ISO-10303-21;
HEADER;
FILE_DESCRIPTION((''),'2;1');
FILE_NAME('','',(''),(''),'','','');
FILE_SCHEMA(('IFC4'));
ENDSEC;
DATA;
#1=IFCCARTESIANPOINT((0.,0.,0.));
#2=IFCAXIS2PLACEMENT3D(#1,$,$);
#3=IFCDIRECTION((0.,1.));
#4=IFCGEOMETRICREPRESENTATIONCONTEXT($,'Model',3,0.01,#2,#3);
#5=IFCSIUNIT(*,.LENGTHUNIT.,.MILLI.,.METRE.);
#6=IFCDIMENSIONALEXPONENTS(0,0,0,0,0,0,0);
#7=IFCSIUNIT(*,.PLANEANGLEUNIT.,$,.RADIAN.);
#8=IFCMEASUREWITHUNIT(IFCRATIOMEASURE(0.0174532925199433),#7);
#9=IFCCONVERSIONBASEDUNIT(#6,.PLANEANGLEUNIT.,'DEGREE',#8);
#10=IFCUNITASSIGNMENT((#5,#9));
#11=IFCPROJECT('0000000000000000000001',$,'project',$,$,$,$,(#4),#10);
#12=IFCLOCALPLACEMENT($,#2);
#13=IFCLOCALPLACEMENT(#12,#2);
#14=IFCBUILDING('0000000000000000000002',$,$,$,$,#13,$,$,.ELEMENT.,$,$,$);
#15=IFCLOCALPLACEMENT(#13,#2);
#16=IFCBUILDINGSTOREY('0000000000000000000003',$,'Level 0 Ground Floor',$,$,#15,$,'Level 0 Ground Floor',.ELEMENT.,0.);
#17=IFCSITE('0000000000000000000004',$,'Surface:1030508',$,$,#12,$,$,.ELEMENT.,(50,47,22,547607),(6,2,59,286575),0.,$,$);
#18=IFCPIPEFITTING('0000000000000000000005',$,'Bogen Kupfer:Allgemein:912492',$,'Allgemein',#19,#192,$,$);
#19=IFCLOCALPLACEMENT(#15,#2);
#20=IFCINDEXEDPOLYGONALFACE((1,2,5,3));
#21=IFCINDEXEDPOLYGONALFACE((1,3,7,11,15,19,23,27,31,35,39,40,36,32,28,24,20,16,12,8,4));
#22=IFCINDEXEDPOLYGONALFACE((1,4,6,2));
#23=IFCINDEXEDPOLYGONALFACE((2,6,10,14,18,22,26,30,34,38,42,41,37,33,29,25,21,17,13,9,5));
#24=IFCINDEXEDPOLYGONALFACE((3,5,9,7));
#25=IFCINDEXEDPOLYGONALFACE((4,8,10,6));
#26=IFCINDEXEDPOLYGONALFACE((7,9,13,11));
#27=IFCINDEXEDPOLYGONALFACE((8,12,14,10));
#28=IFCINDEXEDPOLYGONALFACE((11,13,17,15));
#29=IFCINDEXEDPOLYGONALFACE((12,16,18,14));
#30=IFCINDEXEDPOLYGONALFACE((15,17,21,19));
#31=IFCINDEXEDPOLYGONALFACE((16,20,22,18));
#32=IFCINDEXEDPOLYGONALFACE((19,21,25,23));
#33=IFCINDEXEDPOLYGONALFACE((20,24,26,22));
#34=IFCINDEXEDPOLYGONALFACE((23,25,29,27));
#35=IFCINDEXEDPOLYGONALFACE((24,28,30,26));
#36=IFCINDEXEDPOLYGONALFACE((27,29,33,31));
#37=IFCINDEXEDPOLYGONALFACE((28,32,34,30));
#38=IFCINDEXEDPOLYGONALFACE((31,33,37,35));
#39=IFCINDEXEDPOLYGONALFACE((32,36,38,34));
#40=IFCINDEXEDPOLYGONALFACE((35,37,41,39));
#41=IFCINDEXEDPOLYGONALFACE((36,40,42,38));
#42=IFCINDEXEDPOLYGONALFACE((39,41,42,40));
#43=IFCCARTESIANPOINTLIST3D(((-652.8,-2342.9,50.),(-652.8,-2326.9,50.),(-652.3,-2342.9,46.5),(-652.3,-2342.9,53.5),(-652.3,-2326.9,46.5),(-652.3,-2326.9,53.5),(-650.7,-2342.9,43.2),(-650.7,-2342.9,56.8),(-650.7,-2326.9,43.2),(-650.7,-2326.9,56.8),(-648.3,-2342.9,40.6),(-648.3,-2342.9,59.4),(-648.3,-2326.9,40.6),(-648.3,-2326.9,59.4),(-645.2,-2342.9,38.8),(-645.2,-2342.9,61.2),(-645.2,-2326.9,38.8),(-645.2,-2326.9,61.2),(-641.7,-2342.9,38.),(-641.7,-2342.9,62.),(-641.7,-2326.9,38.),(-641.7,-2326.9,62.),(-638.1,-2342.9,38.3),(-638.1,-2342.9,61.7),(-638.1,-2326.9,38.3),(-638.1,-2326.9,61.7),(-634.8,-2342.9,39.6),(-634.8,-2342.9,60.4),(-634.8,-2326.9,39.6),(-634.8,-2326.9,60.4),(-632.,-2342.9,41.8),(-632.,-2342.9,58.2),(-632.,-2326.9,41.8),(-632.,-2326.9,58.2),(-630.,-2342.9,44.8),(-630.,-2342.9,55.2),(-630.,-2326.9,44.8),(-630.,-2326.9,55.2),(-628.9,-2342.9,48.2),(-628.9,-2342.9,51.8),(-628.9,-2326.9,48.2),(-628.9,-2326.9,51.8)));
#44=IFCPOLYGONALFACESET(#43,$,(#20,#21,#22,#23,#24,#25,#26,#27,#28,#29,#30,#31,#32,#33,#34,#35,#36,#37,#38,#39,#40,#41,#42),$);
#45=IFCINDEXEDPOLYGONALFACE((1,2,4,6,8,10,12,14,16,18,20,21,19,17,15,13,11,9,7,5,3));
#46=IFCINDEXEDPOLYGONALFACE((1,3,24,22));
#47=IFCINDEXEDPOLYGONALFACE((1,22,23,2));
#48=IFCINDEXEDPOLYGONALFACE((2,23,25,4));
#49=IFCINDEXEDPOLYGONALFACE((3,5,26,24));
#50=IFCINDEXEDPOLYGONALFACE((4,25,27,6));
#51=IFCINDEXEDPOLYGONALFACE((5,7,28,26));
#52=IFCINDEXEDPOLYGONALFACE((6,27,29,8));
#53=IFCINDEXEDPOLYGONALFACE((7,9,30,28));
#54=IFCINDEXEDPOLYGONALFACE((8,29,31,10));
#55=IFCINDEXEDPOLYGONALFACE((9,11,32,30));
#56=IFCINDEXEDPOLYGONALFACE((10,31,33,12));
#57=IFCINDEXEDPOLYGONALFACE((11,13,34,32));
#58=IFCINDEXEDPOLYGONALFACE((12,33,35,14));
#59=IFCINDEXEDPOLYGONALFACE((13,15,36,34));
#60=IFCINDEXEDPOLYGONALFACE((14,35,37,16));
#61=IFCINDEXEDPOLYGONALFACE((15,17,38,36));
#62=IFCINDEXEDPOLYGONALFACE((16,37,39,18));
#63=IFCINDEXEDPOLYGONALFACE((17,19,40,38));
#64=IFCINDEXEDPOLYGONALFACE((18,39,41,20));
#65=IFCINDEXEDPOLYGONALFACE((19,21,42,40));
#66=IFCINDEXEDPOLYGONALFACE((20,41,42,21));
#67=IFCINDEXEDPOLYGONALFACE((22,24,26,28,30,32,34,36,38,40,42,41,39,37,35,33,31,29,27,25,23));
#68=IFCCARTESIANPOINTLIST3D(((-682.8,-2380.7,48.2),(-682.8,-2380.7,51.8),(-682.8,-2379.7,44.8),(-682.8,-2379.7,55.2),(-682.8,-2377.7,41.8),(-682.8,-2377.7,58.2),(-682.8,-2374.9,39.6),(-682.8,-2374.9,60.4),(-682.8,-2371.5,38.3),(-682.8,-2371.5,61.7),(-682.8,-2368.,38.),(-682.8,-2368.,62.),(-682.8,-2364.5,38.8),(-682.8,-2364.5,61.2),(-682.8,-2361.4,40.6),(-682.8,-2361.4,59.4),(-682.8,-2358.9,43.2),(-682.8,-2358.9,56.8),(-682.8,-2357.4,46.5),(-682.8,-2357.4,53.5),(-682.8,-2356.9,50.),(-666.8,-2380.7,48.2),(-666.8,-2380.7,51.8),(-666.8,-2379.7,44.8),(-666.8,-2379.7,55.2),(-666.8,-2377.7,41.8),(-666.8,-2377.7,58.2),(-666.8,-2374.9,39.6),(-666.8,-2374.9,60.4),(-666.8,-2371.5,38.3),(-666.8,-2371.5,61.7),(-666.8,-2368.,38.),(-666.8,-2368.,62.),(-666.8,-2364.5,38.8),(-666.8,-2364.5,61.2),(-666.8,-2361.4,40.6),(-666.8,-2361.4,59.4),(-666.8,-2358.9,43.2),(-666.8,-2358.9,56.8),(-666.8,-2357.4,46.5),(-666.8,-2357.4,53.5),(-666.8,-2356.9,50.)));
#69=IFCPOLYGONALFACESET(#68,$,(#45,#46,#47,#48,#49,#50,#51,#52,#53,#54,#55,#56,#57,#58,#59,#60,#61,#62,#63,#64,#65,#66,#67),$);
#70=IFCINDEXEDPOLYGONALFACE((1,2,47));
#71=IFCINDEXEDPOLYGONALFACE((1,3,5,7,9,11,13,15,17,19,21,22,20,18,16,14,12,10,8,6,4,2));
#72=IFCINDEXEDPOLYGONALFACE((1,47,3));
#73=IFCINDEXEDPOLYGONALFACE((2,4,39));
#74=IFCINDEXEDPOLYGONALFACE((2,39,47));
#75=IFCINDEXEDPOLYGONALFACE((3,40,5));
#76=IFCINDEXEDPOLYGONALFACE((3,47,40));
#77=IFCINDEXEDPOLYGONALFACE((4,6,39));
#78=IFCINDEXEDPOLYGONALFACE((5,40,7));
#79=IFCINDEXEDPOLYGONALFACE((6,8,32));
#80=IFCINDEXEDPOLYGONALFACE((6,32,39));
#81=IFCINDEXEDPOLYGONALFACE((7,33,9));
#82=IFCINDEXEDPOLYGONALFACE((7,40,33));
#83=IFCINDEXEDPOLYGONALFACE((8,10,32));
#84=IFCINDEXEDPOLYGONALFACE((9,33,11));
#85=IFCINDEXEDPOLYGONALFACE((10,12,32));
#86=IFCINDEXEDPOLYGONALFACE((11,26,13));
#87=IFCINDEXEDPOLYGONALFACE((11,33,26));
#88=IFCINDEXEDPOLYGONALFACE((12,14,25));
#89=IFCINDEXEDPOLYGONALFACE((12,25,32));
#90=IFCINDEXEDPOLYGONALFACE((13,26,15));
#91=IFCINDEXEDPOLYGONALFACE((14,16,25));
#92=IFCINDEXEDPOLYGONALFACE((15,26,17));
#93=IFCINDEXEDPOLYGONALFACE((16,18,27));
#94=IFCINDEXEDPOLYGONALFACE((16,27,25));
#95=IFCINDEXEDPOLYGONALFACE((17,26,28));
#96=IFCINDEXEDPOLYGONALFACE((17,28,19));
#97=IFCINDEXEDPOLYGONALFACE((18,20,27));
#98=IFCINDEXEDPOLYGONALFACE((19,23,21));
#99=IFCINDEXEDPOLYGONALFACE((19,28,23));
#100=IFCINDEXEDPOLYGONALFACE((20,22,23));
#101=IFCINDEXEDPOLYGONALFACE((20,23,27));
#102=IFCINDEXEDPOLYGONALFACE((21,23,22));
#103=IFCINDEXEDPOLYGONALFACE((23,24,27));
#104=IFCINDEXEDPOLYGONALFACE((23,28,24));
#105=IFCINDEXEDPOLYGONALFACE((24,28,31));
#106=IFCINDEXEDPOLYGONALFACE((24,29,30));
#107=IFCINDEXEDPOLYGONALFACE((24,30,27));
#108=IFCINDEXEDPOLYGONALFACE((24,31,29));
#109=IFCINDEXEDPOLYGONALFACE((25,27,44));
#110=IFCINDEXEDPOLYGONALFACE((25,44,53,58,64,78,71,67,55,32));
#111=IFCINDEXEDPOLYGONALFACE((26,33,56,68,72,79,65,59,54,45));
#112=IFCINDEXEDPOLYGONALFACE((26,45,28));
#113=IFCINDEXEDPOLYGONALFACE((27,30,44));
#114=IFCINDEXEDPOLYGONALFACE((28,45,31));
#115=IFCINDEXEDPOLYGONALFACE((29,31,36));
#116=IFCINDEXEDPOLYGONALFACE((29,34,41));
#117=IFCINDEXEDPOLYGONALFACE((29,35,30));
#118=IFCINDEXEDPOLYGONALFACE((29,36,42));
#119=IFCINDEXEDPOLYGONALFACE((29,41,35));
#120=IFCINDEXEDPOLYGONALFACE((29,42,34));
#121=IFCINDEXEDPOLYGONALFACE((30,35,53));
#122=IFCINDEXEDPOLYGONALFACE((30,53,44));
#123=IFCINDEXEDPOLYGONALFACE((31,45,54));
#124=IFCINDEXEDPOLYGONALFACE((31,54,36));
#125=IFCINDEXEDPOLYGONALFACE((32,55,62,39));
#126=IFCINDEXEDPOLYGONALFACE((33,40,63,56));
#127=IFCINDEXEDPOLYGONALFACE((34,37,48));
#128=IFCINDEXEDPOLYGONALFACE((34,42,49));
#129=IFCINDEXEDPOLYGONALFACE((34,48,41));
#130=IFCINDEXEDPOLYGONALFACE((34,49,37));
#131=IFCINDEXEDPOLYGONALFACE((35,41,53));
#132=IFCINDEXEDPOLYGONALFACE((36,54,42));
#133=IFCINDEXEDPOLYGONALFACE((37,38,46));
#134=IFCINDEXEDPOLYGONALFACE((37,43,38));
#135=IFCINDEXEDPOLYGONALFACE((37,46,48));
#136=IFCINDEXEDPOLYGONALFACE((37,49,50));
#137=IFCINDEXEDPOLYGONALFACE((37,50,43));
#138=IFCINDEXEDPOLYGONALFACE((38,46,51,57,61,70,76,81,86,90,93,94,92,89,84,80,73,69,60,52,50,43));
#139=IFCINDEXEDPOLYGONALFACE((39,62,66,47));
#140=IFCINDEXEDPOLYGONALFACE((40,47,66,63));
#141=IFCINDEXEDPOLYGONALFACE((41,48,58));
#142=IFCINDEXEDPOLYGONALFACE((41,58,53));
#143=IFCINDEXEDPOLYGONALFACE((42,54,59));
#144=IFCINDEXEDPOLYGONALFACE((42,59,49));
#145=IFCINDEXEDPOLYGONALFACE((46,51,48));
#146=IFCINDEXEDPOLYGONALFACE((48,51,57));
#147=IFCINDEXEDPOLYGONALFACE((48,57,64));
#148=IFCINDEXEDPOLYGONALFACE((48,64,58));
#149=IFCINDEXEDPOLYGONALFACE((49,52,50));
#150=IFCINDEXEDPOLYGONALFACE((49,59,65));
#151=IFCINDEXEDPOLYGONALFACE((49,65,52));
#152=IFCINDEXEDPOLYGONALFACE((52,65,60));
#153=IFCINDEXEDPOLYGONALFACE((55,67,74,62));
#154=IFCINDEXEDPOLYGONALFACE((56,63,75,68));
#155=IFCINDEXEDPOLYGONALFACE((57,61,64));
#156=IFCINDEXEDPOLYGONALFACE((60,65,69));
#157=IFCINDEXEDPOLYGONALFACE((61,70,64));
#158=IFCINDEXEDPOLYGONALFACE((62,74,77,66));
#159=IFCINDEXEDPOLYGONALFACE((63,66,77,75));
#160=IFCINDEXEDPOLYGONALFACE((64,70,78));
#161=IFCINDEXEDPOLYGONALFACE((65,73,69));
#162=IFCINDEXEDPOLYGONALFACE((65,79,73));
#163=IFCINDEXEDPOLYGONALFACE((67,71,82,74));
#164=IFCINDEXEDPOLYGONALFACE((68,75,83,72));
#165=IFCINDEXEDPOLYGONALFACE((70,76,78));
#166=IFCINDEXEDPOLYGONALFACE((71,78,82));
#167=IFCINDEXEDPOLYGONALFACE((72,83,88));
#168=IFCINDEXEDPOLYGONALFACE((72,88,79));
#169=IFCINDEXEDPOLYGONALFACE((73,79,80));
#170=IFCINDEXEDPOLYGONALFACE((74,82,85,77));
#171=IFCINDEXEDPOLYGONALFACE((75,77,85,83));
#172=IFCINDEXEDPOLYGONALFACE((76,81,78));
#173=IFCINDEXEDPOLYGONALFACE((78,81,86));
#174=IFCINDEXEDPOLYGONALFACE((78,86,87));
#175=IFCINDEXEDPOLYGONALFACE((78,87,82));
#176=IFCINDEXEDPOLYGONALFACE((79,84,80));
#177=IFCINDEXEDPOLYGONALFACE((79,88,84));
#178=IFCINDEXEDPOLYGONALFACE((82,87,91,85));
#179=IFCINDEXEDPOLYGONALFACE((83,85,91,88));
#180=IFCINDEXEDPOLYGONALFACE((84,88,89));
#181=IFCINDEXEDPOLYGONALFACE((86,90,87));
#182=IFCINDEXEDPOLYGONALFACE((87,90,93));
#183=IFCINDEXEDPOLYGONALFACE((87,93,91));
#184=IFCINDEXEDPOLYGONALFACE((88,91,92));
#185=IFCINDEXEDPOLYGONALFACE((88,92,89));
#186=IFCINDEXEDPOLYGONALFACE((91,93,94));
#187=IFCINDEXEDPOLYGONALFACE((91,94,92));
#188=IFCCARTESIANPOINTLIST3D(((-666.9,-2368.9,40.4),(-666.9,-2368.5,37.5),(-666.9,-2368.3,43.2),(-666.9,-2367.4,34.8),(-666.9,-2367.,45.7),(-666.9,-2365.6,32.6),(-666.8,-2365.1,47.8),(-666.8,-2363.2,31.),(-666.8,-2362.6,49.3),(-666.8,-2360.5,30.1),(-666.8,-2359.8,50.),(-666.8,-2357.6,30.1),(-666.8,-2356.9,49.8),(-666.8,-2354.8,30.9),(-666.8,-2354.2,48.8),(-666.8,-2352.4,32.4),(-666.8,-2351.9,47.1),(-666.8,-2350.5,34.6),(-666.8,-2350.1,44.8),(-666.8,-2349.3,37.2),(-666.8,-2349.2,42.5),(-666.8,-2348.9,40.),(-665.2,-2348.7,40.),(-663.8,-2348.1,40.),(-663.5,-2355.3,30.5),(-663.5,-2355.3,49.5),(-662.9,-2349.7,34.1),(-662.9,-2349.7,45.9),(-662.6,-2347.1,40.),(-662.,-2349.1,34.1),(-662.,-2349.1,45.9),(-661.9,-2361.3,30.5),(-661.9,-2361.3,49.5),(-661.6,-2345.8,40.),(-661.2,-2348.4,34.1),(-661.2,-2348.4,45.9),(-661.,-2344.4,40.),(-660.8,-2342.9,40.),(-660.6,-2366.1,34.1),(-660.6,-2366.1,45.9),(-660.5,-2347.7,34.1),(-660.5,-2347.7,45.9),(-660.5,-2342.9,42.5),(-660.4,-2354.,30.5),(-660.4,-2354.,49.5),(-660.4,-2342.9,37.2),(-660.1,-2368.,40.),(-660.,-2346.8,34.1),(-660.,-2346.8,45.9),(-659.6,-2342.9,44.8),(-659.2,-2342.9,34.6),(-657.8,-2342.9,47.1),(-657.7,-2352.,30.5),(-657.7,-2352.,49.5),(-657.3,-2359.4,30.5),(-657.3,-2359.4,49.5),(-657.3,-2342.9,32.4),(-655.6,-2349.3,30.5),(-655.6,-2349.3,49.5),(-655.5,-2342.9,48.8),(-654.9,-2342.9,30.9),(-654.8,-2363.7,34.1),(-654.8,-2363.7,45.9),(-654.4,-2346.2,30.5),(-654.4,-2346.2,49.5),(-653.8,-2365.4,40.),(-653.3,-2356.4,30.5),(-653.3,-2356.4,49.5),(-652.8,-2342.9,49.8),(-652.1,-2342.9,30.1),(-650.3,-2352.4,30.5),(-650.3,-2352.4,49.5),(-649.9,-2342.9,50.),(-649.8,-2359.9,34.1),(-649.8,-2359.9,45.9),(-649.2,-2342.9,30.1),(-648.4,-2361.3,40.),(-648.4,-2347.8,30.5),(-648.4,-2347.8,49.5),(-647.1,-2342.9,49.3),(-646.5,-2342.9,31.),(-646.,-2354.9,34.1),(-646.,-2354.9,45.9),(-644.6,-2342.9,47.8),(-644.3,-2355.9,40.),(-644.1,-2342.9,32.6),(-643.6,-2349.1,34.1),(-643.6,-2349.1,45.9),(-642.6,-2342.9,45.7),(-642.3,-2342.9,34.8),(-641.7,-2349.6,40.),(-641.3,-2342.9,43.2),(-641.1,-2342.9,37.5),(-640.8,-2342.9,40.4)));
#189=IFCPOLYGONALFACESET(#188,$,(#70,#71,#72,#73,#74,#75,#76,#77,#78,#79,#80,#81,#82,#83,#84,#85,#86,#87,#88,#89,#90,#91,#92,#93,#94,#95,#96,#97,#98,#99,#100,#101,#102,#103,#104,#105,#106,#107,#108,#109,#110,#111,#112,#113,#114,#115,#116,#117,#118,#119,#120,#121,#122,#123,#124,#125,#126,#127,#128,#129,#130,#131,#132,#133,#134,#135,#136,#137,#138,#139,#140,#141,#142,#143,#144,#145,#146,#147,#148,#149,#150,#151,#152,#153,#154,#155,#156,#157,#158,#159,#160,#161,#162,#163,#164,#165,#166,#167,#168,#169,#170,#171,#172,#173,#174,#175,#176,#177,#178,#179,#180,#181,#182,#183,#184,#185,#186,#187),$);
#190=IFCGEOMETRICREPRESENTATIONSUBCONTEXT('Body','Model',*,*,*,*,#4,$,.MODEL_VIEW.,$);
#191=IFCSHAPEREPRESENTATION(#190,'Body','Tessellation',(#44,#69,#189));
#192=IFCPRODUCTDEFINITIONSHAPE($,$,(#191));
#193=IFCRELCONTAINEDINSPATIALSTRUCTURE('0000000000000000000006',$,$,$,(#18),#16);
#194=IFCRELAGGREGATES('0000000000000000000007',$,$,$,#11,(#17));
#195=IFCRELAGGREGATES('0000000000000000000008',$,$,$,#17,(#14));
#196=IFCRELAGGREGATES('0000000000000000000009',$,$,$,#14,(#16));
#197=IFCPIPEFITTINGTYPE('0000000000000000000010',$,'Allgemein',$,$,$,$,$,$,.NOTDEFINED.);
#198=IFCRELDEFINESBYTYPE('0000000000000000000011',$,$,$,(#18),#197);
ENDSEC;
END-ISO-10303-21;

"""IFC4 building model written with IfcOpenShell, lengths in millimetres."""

from ifc_helpers import new_model, entity, si_unit, converted_unit, direction, frame, frame_2d, origin, place, context, subcontext, project, spatial, circle, extrude, source, transform, mapped, type_object, type_shapes, element, save


model = new_model("IFC4")

# Units and contexts
model_context = context("Model", 3, precision=0.01, world=origin(), true_north=direction((0.0, 1.0)))
body_context = subcontext(model_context, "Body", "Model", "MODEL_VIEW")
ifc_project = project(units=[si_unit("LENGTHUNIT", "METRE", prefix="MILLI"), converted_unit("PLANEANGLEUNIT", "DEGREE", entity("IfcRatioMeasure", 0.0174532925199433), si_unit("PLANEANGLEUNIT", "RADIAN"), dimensions=[0, 0, 0, 0, 0, 0, 0])], contexts=[model_context])

# Site, building, storey
site_placement = place(None, origin())
site = spatial("IfcSite", under=ifc_project, at=site_placement, Name="Surface:1030508", CompositionType="ELEMENT", RefLatitude=(50, 47, 22, 547607), RefLongitude=(6, 2, 59, 286575), RefElevation=0.0)
building_placement = place(site_placement, origin())
building = spatial("IfcBuilding", under=site, at=building_placement, CompositionType="ELEMENT")
storey_placement = place(building_placement, origin())
storey = spatial("IfcBuildingStorey", under=building, at=storey_placement, Name="Level 0 Ground Floor", LongName="Level 0 Ground Floor", CompositionType="ELEMENT", Elevation=0.0)

# Pipe fitting
pipe_fitting_type_1 = type_object("IfcPipeFittingType", Name="Allgemein", PredefinedType="NOTDEFINED")
ifc_direction_1 = entity("IfcDirection", [0.0, 0.0, -1.0])
trimmed_curve_1 = entity("IfcTrimmedCurve", entity("IfcCircle", entity("IfcAxis2Placement2D", entity("IfcCartesianPoint", [-16.0, 0.0]), entity("IfcDirection", [0.0, 1.0])), 16.0), [entity("IfcParameterValue", 270.0)], [entity("IfcParameterValue", 0.0)], True, "PARAMETER")
shared_shape_1 = source(origin(), body_context, "Body", "SolidModel", [
    extrude(circle(Radius=12.0, at=frame_2d((0.0, 0.0), x_axis=(1.0, 0.0))), frame((0.0, 26.0, 0.0), z_axis=(0.0, 1.0, 0.0), x_axis=(-1.0, 0.0, 0.0)), (0.0, 0.0, 1.0), 16.0),
    extrude(circle(Radius=12.0, at=frame_2d((0.0, 0.0), x_axis=(1.0, 0.0))), frame((-42.0, 0.0, 0.0), z_axis=(1.0, 0.0, 0.0), x_axis=(0.0, 1.0, 0.0)), (0.0, 0.0, 1.0), 16.0),
    entity("IfcSurfaceCurveSweptAreaSolid", entity("IfcCircleProfileDef", "AREA", None, entity("IfcAxis2Placement2D", entity("IfcCartesianPoint", [0.0, 10.0]), entity("IfcDirection", [1.0, 0.0])), 10.0), entity("IfcAxis2Placement3D", entity("IfcCartesianPoint", [-10.0, 26.0, 0.0]), ifc_direction_1, entity("IfcDirection", [1.0, 0.0, 0.0])), trimmed_curve_1, 0.0, 90.0, entity("IfcSurfaceOfLinearExtrusion", entity("IfcArbitraryOpenProfileDef", "CURVE", None, trimmed_curve_1), entity("IfcAxis2Placement3D", entity("IfcCartesianPoint", [0.0, 0.0, -304.8])), ifc_direction_1, 1.0)),
])
type_shapes(pipe_fitting_type_1, [shared_shape_1])
pipe_fitting_1_placement = place(storey_placement, frame((-640.8, -2368.9, 50.0)))
element("IfcPipeFitting", 1, at=pipe_fitting_1_placement, inside=storey, type_object=pipe_fitting_type_1, Name="Bogen Kupfer:Allgemein:912492", ObjectType="Allgemein", context=body_context, shape_type="MappedRepresentation", body=[
    mapped(shared_shape_1, transform((0.0, 0.0, 0.0), scale=1.0)),
])

save(model, "model.ifc")
